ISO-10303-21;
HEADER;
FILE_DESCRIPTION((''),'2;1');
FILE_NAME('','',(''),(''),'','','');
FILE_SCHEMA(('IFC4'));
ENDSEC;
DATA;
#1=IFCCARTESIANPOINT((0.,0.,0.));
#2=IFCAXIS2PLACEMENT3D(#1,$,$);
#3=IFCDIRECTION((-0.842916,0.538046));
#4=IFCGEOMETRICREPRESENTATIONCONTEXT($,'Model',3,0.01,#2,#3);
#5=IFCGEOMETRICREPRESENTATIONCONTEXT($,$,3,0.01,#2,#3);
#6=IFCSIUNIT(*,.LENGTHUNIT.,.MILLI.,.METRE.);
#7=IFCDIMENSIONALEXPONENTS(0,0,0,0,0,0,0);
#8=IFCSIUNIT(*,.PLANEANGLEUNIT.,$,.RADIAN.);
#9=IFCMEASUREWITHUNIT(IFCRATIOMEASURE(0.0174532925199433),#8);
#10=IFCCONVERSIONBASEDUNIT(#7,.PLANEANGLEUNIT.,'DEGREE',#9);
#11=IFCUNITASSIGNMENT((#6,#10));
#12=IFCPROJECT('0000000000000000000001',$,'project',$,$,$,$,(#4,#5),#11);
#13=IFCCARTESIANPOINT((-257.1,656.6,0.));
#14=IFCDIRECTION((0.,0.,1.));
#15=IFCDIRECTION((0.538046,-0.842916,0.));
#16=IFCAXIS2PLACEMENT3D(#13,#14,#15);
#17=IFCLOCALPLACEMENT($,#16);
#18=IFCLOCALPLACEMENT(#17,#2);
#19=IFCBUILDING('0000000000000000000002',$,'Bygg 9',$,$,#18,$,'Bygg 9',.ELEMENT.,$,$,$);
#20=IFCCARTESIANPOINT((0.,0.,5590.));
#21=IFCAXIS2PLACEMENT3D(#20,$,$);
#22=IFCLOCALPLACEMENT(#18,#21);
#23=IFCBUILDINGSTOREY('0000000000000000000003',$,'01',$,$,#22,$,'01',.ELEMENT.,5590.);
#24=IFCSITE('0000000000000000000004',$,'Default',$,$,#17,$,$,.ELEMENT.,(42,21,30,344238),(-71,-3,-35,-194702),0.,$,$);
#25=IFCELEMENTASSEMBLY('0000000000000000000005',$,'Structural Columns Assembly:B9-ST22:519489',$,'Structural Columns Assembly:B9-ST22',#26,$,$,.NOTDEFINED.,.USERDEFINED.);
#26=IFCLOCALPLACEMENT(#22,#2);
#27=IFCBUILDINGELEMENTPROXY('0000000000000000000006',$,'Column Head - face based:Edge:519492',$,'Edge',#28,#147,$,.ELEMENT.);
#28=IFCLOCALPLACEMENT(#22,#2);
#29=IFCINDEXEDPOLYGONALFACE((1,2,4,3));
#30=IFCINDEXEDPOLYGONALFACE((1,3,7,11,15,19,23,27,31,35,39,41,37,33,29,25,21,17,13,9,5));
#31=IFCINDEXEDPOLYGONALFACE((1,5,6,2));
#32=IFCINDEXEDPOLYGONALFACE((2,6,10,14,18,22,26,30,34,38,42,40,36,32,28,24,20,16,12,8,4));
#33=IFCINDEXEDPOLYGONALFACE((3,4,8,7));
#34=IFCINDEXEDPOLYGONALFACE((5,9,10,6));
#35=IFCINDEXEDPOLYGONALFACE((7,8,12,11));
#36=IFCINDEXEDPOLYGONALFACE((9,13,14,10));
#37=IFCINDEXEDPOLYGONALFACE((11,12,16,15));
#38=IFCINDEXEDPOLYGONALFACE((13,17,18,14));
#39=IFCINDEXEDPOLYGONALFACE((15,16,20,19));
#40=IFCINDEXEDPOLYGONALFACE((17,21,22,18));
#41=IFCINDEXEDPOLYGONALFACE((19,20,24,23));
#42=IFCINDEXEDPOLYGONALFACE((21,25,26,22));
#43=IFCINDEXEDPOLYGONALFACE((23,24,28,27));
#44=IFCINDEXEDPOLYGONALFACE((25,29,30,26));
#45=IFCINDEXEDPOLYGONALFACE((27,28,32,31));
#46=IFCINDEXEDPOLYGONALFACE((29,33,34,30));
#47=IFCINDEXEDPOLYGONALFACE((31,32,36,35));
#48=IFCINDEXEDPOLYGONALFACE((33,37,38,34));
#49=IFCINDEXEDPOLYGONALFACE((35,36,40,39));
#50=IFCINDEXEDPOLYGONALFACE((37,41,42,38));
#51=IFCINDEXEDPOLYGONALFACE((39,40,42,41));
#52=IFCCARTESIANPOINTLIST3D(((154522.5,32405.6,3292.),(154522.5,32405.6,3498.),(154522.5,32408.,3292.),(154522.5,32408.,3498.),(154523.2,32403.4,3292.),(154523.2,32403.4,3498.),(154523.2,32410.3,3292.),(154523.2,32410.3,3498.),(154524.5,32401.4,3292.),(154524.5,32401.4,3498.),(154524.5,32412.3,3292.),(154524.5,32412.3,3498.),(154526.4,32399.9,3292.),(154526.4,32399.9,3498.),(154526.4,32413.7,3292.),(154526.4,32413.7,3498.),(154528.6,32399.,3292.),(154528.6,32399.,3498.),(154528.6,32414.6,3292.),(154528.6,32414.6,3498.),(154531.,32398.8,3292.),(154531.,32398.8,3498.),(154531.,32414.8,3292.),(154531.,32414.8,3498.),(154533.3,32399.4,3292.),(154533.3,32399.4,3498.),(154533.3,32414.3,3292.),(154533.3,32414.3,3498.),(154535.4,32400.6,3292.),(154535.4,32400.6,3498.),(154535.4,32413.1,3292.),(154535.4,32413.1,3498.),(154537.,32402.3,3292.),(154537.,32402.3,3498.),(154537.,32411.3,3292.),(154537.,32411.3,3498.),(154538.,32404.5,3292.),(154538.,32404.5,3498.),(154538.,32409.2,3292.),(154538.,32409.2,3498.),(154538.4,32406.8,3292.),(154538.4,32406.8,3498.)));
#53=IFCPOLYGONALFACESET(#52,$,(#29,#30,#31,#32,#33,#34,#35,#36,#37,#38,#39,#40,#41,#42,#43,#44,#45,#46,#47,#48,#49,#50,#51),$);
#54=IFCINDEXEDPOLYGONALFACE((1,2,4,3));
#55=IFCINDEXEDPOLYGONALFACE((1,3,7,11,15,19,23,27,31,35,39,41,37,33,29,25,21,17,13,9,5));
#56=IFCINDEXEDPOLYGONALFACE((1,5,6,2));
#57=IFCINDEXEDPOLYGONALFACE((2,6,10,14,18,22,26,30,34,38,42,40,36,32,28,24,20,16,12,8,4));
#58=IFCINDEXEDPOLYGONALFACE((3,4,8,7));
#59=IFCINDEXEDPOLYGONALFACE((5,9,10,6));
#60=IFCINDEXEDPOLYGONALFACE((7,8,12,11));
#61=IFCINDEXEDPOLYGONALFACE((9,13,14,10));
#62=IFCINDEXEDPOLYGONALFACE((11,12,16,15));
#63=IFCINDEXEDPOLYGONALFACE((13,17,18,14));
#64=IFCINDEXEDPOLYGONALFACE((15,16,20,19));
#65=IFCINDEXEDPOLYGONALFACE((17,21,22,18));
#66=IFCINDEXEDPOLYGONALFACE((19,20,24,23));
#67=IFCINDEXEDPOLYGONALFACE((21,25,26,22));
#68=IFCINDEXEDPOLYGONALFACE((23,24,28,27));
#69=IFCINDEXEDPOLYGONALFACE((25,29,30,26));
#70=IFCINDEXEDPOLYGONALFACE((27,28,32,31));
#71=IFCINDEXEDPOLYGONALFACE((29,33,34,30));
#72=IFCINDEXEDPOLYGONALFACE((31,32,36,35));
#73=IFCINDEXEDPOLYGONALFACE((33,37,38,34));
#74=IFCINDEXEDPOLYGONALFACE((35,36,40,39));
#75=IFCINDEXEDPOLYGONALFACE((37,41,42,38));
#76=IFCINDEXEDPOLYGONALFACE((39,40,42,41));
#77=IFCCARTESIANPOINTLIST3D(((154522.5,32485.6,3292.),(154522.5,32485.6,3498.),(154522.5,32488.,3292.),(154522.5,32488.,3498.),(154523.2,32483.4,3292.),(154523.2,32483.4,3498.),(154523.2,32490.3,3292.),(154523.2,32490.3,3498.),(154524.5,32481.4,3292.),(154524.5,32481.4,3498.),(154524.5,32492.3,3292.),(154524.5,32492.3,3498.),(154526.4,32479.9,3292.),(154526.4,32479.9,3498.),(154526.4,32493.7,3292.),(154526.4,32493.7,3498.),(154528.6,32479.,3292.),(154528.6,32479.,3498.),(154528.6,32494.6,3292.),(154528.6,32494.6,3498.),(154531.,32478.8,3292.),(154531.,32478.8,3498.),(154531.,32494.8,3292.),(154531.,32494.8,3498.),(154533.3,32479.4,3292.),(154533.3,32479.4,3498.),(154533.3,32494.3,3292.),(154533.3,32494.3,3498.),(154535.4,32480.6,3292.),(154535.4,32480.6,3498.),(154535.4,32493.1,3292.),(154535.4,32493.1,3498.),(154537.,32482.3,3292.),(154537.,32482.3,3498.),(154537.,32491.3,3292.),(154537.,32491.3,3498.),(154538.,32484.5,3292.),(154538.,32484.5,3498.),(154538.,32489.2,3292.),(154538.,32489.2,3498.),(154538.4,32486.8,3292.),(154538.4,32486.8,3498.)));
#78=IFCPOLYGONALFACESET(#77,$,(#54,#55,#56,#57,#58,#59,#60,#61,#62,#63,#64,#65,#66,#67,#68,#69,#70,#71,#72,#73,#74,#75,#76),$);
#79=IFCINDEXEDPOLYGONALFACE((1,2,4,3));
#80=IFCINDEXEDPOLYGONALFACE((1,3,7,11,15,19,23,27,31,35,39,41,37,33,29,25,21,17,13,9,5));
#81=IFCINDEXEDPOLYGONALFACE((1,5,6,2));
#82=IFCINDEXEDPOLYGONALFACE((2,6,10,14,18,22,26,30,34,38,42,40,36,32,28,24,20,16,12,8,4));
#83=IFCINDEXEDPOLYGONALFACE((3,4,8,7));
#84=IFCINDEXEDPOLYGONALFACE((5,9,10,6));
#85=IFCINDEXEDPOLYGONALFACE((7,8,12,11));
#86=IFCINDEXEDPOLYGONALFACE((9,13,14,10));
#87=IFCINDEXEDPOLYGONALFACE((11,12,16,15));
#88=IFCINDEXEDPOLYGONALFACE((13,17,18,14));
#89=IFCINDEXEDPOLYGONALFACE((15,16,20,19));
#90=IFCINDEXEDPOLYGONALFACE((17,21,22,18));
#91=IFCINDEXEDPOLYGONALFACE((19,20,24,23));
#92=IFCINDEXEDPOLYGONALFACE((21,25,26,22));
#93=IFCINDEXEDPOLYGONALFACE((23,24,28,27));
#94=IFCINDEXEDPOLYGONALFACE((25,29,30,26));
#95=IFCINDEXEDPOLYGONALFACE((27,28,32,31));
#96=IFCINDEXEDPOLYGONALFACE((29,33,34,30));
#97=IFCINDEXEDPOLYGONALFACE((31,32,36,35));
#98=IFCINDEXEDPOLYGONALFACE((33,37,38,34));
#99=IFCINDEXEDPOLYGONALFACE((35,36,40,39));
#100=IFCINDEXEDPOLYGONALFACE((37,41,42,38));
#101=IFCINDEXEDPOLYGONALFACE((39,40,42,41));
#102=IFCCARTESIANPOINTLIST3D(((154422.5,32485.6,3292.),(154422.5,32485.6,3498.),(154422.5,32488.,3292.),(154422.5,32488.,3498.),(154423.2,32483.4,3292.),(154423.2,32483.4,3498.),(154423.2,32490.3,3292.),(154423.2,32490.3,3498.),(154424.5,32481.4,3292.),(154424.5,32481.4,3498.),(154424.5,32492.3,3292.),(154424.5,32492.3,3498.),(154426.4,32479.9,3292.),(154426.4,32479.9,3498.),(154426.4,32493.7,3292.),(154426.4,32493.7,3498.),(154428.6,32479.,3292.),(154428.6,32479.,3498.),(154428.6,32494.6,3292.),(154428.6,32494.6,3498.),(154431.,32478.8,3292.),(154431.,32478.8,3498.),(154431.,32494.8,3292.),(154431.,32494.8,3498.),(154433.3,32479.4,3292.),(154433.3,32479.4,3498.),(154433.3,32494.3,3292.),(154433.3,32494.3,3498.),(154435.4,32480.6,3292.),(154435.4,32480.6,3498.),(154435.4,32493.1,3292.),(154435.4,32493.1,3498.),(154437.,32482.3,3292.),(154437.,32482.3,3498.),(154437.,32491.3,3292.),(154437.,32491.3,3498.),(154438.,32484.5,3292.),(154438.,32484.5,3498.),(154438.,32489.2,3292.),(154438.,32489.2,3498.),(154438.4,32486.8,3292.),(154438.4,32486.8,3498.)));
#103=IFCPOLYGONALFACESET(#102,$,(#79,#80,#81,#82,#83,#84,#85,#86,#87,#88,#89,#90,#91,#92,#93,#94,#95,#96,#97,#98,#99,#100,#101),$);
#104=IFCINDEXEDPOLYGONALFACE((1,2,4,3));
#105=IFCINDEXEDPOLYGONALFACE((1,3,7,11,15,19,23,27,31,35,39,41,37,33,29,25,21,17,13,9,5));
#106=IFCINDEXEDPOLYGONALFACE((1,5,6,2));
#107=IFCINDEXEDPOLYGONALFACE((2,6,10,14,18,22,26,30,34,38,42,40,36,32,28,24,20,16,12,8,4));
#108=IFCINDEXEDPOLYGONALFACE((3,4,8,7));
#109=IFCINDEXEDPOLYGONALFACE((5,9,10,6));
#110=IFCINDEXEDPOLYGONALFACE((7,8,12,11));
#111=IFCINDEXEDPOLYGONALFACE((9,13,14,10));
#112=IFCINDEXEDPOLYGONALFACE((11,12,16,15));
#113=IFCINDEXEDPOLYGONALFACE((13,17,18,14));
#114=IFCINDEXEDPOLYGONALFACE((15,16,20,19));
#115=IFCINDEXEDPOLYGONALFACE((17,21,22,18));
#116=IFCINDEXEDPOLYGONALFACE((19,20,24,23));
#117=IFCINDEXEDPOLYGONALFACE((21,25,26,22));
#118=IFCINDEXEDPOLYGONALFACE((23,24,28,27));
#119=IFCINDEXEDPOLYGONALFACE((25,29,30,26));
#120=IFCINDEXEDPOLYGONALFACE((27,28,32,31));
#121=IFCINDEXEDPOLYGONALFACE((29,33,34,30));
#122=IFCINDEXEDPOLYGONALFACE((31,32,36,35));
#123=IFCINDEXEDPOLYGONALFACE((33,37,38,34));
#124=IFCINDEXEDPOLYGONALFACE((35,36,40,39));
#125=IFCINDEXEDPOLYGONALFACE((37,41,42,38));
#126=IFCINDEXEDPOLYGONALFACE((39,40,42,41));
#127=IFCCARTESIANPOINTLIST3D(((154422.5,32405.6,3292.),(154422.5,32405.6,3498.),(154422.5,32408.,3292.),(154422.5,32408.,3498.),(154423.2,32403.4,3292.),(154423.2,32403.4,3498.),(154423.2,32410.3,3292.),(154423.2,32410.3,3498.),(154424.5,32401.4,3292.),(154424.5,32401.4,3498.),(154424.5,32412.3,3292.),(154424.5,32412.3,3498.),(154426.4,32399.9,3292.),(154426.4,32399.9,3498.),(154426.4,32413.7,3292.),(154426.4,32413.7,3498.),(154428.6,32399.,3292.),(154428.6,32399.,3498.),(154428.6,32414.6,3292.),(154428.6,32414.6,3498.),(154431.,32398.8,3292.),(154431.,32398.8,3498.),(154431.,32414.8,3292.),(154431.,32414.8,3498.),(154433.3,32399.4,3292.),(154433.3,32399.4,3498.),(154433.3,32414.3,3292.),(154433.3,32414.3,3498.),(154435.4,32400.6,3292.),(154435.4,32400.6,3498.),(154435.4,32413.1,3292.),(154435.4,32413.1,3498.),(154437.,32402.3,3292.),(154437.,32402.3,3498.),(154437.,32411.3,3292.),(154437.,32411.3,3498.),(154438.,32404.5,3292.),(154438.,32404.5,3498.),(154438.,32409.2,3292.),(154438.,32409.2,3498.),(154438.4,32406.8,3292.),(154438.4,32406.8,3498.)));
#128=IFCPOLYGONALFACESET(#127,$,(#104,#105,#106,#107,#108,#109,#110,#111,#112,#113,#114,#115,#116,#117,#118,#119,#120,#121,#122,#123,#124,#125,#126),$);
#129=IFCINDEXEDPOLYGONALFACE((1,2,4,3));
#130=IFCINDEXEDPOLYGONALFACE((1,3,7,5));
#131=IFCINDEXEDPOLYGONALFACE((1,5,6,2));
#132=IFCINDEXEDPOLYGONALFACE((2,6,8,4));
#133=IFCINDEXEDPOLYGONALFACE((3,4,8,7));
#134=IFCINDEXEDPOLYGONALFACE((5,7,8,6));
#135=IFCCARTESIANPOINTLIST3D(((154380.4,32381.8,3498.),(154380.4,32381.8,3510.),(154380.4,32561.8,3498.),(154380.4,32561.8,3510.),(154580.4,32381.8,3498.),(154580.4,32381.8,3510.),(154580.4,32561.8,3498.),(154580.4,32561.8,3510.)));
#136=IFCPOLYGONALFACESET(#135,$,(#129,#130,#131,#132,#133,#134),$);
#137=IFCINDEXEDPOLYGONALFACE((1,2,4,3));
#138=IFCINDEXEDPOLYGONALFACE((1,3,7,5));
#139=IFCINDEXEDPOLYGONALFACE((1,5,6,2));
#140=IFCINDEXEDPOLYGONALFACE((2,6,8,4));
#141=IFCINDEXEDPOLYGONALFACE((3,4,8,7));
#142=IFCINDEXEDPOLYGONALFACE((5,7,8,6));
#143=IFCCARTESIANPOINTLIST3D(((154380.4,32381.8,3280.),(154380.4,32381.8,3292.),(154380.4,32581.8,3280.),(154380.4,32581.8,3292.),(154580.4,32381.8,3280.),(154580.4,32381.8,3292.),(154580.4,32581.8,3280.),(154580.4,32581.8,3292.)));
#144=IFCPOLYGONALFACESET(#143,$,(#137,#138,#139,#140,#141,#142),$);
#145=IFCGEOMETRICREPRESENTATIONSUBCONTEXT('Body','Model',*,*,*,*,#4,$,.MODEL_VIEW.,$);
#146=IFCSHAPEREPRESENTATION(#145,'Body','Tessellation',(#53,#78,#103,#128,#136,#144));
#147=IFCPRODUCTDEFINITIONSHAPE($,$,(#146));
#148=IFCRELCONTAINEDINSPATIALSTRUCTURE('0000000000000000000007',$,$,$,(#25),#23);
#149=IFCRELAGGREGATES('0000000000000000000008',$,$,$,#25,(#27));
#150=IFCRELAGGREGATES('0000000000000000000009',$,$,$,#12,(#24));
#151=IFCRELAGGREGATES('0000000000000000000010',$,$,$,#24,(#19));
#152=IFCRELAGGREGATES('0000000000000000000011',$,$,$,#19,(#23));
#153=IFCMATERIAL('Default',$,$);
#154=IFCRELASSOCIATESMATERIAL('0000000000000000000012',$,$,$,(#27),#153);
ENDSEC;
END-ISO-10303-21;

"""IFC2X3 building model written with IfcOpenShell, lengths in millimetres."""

from ifc_helpers import new_model, entity, si_unit, converted_unit, direction, frame, frame_2d, origin, origin_2d_with_axis, place, context, subcontext, project, spatial, rectangle, circle, extrude, source, transform, mapped, material, element, aggregate, save


model = new_model("IFC2X3")

# Units and contexts
model_context = context("Model", 3, precision=0.01, world=origin(), true_north=direction((-0.842916, 0.538046)))
context_of_model = context(None, 3, precision=0.01, world=origin(), true_north=direction((-0.842916, 0.538046)))
body_context = subcontext(model_context, "Body", "Model", "MODEL_VIEW")
ifc_project = project(units=[si_unit("LENGTHUNIT", "METRE", prefix="MILLI"), converted_unit("PLANEANGLEUNIT", "DEGREE", entity("IfcRatioMeasure", 0.0174532925199433), si_unit("PLANEANGLEUNIT", "RADIAN"), dimensions=[0, 0, 0, 0, 0, 0, 0])], contexts=[model_context, context_of_model])

# Site, building, storey
site_placement = place(None, frame((-257.1, 656.6, 0.0), z_axis=(0.0, 0.0, 1.0), x_axis=(0.538046, -0.842916, 0.0)))
site = spatial("IfcSite", under=ifc_project, at=site_placement, Name="Default", CompositionType="ELEMENT", RefLatitude=(42, 21, 30, 344238), RefLongitude=(-71, -3, -35, -194702), RefElevation=0.0)
building_placement = place(site_placement, origin())
building = spatial("IfcBuilding", under=site, at=building_placement, Name="Bygg 9", LongName="Bygg 9", CompositionType="ELEMENT")
storey_placement = place(building_placement, frame((0.0, 0.0, 5590.0)))
storey = spatial("IfcBuildingStorey", under=building, at=storey_placement, Name="01", LongName="01", CompositionType="ELEMENT", Elevation=5590.0)

# Shared definitions
ifc_material_1 = material(Name="Default")

# Element assembly, building element proxy
assembly_1_placement = place(storey_placement, origin())
assembly_1 = element("IfcElementAssembly", 1, at=assembly_1_placement, inside=storey, Name="Structural Columns Assembly:B9-ST22:519489", ObjectType="Structural Columns Assembly:B9-ST22", AssemblyPlace="NOTDEFINED", PredefinedType="USERDEFINED")
shared_shape_1 = source(origin(), body_context, "Body", "SweptSolid", [
    extrude(circle(Radius=8.0, at=frame_2d((0.0, 0.0), x_axis=(1.0, 0.0))), frame((50.0, -135.0, 12.0)), (0.0, 0.0, 1.0), 206.0),
    extrude(circle(Radius=8.0, at=frame_2d((0.0, 0.0), x_axis=(1.0, 0.0))), frame((50.0, -55.0, 12.0)), (0.0, 0.0, 1.0), 206.0),
    extrude(circle(Radius=8.0, at=frame_2d((0.0, 0.0), x_axis=(1.0, 0.0))), frame((-50.0, -55.0, 12.0)), (0.0, 0.0, 1.0), 206.0),
    extrude(circle(Radius=8.0, at=frame_2d((0.0, 0.0), x_axis=(1.0, 0.0))), frame((-50.0, -135.0, 12.0)), (0.0, 0.0, 1.0), 206.0),
    extrude(rectangle(XDim=200.0, YDim=180.0, at=origin_2d_with_axis()), frame((0.0, -70.0, 218.0), z_axis=(0.0, 0.0, 1.0), x_axis=(-1.0, 0.0, 0.0)), (0.0, 0.0, 1.0), 12.0),
    extrude(rectangle(XDim=200.0, YDim=200.0, at=origin_2d_with_axis()), frame((0.0, -60.0, 0.0), z_axis=(0.0, 0.0, 1.0), x_axis=(0.0, 1.0, 0.0)), (0.0, 0.0, 1.0), 12.0),
])
proxy_1_placement = place(assembly_1_placement, frame((154480.4, 32541.8, 3280.0)))
proxy_1 = element("IfcBuildingElementProxy", 2, at=proxy_1_placement, material=ifc_material_1, Name="Column Head - face based:Edge:519492", ObjectType="Edge", CompositionType="ELEMENT", context=body_context, shape_type="MappedRepresentation", body=[
    mapped(shared_shape_1, transform((0.0, 0.0, 0.0), scale=1.0)),
])
aggregate(assembly_1, [proxy_1])

save(model, "model.ifc")
